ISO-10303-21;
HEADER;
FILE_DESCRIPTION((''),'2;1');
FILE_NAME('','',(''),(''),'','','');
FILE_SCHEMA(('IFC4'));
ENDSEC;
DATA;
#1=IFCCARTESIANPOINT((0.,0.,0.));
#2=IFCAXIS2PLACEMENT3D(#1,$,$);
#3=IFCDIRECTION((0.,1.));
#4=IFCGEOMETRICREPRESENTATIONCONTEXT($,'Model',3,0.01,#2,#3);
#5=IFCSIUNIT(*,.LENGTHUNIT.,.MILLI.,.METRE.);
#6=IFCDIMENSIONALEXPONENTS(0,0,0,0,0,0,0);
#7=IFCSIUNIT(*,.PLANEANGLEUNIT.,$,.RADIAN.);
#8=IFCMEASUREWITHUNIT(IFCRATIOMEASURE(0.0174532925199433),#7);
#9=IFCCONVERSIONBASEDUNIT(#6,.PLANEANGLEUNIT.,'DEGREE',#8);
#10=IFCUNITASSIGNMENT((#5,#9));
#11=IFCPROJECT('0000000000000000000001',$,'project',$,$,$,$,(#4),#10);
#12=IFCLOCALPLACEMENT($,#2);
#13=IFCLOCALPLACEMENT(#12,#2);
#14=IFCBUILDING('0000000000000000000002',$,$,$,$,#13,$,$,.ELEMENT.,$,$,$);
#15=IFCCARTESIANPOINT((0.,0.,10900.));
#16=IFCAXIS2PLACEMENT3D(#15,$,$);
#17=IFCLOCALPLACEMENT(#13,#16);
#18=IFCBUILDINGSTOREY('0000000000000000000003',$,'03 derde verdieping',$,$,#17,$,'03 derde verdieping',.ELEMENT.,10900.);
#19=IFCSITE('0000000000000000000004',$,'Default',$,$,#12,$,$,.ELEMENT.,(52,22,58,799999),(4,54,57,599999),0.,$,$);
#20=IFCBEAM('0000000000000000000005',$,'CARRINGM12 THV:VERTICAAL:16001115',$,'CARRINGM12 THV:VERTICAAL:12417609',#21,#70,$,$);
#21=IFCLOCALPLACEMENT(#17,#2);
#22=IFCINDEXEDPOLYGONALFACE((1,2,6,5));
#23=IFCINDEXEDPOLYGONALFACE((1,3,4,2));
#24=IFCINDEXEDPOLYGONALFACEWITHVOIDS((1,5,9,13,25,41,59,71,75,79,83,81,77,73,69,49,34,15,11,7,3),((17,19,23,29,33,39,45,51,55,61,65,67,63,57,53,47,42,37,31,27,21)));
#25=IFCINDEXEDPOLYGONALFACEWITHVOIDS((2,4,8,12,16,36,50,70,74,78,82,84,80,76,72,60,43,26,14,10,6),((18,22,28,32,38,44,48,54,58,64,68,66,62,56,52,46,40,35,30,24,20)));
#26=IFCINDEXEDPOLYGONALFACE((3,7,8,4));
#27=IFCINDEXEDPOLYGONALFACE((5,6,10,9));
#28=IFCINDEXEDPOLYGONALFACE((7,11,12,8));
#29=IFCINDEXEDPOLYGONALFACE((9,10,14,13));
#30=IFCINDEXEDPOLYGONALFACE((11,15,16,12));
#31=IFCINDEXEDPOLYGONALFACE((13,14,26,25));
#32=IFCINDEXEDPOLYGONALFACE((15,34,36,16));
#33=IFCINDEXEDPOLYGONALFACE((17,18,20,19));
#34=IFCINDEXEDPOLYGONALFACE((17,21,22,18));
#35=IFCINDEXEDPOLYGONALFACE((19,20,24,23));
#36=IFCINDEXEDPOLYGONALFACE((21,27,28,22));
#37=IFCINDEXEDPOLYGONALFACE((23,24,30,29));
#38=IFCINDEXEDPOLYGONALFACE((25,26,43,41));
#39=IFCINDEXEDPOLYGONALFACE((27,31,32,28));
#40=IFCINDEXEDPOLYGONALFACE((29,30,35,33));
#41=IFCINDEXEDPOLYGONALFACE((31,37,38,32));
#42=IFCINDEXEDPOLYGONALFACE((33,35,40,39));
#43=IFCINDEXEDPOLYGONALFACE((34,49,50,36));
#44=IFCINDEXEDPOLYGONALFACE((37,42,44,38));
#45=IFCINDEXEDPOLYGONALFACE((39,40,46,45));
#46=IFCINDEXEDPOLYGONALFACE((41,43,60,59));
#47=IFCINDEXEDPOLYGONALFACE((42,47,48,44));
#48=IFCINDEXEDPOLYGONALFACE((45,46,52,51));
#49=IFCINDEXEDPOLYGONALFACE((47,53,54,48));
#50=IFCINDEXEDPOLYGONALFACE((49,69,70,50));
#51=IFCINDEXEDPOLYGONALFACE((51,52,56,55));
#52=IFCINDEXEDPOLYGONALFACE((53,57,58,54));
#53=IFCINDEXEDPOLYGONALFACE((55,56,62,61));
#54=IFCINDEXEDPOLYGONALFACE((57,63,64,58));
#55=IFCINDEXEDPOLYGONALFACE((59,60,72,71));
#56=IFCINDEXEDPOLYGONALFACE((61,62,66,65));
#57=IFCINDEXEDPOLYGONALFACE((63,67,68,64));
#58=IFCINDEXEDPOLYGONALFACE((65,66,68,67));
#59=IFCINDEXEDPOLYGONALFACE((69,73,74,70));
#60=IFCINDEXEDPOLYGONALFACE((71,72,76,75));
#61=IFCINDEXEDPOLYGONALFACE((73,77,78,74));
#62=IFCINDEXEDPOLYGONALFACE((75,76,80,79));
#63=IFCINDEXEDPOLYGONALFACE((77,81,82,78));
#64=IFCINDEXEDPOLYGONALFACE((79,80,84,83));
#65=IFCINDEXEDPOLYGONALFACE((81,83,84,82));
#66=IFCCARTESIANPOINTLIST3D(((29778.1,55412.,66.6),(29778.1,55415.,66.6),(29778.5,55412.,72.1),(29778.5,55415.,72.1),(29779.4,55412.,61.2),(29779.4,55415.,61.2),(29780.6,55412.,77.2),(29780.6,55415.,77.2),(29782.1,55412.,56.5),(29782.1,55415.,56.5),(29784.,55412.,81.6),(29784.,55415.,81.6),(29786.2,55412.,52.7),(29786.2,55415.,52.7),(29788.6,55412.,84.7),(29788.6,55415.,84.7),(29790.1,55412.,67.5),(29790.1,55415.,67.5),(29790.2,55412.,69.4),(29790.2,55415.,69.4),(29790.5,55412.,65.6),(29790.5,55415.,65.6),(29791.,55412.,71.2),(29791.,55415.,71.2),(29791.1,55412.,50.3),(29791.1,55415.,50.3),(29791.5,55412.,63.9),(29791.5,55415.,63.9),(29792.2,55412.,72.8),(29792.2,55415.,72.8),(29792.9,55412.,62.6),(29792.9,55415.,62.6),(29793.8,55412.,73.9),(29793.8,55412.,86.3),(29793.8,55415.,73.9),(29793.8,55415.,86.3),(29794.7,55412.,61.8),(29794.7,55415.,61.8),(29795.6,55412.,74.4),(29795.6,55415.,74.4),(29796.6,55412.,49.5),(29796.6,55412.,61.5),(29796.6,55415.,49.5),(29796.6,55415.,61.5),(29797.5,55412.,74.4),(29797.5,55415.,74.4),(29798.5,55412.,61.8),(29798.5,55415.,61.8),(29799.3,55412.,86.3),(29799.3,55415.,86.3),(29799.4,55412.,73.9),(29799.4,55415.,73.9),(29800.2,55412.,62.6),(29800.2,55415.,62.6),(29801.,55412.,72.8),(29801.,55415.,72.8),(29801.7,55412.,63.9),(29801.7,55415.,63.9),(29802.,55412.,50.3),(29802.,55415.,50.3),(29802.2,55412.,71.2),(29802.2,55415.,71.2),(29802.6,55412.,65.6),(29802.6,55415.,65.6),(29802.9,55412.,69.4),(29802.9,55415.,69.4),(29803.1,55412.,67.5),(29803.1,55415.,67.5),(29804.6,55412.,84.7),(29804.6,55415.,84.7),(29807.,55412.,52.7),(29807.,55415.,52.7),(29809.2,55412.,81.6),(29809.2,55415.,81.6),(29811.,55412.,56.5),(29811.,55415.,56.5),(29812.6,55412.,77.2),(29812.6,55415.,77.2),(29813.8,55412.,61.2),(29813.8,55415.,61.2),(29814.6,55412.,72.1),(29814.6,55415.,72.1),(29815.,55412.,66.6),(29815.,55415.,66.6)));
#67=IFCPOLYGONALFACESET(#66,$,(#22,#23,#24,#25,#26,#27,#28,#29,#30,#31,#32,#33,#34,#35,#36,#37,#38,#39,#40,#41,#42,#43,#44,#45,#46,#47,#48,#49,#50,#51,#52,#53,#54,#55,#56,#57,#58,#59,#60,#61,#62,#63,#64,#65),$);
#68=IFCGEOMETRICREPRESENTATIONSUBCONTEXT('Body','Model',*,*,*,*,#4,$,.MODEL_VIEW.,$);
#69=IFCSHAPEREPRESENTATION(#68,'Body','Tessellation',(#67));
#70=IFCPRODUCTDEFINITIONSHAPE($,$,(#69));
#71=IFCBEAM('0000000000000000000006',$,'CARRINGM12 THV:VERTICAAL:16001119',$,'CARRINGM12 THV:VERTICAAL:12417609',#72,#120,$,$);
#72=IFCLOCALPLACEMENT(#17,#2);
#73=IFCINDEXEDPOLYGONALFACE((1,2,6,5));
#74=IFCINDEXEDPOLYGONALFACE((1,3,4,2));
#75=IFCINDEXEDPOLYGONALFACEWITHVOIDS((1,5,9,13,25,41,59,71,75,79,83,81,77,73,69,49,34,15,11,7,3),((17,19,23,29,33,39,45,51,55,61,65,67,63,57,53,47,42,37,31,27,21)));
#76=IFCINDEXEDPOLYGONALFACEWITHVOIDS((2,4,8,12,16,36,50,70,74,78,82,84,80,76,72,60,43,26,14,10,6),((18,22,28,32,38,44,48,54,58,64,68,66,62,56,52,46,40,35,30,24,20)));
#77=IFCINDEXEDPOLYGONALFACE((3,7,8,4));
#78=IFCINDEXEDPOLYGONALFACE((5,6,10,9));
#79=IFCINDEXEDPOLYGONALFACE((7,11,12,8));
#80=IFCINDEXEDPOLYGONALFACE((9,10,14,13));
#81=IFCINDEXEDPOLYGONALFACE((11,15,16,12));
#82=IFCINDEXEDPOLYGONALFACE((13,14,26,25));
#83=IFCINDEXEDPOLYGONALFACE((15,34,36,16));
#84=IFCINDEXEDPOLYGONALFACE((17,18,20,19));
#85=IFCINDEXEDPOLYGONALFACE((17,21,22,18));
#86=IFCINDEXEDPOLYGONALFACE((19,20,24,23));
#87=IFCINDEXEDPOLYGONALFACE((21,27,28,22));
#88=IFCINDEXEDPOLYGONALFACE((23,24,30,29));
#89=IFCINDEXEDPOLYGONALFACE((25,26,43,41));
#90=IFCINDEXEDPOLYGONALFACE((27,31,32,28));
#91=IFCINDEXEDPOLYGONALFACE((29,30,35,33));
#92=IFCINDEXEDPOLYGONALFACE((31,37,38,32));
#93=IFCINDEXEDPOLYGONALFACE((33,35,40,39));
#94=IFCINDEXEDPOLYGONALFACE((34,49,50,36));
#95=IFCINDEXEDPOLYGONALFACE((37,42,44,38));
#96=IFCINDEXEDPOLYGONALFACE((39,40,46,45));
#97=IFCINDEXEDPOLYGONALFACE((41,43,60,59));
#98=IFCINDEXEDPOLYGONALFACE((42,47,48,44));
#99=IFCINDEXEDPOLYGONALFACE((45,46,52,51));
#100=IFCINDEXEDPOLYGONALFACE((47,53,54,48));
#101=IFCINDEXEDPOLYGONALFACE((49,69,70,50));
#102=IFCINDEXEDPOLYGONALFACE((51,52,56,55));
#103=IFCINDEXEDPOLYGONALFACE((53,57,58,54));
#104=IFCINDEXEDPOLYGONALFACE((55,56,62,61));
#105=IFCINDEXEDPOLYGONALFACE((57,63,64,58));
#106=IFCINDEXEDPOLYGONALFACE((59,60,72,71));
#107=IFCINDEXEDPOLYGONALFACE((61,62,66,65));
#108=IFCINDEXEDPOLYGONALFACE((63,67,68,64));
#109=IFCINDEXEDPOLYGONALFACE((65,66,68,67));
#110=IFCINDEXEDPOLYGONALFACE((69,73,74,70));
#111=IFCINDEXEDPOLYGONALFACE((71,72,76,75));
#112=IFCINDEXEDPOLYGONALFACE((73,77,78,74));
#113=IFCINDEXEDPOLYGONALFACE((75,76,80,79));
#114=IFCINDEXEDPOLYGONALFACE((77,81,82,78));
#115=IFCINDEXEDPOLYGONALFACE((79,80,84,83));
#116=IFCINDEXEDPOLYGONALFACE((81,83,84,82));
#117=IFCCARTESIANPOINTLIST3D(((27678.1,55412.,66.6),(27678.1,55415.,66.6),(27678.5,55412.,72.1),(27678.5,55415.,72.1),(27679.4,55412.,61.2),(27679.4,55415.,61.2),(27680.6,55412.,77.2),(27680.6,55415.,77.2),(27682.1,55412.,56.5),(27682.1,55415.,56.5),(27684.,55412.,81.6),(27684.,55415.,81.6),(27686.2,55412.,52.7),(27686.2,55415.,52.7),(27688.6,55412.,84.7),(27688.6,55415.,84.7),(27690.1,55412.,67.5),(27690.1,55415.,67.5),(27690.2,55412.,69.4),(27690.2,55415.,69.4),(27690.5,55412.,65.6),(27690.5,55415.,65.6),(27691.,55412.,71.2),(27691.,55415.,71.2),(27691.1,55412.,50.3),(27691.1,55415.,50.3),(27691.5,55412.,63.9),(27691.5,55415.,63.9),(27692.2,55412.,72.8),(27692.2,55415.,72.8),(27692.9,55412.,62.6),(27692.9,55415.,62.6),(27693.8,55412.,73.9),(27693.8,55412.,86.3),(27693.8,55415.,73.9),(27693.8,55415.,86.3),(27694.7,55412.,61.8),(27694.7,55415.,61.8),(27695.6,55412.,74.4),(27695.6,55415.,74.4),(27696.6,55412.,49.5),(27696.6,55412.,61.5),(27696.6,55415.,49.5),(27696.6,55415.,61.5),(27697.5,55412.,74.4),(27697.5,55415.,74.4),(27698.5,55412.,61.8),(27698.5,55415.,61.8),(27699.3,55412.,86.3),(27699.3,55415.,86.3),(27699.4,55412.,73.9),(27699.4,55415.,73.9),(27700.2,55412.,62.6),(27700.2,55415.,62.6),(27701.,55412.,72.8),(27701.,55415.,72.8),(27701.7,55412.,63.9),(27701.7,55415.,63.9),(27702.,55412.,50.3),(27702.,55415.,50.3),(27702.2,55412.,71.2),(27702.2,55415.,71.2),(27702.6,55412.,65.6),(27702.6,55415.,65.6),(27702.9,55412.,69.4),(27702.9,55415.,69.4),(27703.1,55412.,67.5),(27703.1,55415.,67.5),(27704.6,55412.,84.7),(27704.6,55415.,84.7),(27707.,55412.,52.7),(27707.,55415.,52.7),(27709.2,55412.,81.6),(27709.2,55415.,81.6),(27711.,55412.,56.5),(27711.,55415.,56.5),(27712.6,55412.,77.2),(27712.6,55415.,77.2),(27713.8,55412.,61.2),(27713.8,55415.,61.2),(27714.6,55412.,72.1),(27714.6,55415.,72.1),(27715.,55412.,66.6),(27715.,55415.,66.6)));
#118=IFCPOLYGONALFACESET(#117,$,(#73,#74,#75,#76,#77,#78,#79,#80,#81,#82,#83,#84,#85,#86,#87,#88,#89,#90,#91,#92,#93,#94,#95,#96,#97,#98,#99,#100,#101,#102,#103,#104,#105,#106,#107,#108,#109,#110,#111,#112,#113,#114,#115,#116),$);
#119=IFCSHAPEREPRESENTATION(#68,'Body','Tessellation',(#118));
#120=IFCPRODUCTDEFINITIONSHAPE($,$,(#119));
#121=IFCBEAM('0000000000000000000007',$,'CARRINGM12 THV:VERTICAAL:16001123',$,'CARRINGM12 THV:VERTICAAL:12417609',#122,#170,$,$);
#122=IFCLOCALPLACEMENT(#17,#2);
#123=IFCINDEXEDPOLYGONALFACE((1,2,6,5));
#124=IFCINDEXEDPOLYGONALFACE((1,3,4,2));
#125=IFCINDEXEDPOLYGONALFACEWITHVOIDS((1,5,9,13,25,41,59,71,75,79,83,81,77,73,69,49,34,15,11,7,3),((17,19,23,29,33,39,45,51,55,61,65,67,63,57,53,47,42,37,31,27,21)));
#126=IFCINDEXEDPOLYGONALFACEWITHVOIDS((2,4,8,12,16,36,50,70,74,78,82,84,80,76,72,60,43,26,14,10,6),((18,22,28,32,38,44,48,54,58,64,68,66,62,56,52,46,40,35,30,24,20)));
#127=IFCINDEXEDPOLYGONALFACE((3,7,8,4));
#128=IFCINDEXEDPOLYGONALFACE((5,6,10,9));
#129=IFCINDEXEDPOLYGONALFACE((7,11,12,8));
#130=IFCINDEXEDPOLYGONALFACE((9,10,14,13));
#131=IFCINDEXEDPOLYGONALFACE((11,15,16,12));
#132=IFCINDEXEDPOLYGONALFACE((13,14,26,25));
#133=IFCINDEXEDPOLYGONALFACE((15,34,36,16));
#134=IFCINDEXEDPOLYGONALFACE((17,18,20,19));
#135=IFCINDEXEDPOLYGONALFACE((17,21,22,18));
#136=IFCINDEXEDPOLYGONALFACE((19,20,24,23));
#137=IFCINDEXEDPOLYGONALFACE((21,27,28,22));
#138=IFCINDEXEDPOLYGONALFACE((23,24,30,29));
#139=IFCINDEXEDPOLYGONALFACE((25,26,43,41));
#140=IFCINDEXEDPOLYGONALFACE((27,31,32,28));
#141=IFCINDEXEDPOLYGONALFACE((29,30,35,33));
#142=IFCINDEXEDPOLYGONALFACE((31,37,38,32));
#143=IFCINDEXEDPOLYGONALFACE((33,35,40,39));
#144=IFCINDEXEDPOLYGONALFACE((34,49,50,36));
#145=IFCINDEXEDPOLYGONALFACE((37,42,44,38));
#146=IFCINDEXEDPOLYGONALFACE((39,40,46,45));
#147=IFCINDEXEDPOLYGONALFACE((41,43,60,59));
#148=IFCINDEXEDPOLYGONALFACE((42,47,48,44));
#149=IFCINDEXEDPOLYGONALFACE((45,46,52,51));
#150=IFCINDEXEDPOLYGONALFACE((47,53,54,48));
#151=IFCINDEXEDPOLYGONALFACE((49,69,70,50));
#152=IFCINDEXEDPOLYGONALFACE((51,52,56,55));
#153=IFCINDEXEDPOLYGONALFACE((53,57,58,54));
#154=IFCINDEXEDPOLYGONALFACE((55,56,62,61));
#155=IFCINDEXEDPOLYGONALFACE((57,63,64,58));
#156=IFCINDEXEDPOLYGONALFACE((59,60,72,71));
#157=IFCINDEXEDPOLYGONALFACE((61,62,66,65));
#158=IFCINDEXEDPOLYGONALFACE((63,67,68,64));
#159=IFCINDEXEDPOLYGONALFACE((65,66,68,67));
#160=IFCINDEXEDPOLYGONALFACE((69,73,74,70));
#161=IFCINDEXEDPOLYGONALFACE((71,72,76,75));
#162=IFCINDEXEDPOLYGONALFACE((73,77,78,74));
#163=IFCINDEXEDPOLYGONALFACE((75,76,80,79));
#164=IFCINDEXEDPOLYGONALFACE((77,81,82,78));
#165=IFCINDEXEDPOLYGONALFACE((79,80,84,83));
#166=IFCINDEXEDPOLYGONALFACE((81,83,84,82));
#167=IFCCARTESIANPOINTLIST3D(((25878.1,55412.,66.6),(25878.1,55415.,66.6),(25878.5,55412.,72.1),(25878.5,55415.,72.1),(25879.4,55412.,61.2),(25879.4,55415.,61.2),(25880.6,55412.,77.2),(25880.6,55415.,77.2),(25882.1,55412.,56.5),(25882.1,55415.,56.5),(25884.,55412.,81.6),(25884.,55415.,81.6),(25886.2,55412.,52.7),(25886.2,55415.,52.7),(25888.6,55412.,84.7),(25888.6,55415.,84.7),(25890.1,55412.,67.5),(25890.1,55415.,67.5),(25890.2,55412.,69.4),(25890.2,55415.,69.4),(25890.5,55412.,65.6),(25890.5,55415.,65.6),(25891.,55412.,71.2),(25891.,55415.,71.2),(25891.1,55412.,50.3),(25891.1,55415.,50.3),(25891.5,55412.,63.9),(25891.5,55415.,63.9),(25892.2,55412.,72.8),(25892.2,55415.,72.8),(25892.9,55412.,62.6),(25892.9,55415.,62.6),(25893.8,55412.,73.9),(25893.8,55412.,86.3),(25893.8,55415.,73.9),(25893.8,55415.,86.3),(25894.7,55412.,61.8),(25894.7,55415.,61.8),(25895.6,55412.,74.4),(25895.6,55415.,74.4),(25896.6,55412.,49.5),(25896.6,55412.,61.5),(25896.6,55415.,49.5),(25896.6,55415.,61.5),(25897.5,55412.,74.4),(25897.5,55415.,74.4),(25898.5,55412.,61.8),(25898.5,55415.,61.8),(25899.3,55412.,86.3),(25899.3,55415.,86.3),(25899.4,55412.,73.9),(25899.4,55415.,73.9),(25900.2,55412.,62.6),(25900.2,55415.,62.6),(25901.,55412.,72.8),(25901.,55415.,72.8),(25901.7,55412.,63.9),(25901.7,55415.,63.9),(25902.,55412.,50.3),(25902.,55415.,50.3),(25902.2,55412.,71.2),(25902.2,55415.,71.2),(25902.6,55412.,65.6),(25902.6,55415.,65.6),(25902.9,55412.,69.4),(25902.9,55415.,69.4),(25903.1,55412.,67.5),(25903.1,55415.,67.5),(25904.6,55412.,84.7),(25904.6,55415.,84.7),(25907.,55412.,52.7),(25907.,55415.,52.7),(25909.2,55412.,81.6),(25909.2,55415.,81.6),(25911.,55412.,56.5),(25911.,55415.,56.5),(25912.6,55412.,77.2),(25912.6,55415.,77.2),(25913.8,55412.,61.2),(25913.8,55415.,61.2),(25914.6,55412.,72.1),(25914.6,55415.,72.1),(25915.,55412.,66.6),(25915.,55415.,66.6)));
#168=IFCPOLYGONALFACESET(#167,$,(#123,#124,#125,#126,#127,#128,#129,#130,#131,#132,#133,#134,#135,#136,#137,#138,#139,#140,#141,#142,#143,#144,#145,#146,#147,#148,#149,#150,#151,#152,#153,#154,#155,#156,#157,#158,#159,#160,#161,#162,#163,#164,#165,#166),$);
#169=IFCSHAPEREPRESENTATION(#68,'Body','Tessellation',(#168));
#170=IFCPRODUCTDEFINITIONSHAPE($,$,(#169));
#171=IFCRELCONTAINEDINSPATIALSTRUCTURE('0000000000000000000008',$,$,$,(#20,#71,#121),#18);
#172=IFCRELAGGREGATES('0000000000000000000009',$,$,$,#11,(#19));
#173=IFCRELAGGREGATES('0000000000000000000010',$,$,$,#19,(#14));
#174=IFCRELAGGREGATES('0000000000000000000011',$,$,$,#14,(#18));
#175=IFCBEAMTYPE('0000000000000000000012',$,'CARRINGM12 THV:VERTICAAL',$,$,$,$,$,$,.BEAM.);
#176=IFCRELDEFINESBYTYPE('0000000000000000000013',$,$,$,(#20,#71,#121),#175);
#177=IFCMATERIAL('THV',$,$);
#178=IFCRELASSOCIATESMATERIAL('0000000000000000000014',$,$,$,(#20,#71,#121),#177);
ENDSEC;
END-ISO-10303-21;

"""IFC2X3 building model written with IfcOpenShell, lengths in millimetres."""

from ifc_helpers import new_model, entity, si_unit, converted_unit, direction, frame, origin, origin_2d_with_axis, place, context, subcontext, project, spatial, hollow_circle, extrude, material, type_object, element, save


model = new_model("IFC2X3")

# Units and contexts
model_context = context("Model", 3, precision=0.01, world=origin(), true_north=direction((0.0, 1.0)))
body_context = subcontext(model_context, "Body", "Model", "MODEL_VIEW")
ifc_project = project(units=[si_unit("LENGTHUNIT", "METRE", prefix="MILLI"), converted_unit("PLANEANGLEUNIT", "DEGREE", entity("IfcRatioMeasure", 0.0174532925199433), si_unit("PLANEANGLEUNIT", "RADIAN"), dimensions=[0, 0, 0, 0, 0, 0, 0])], contexts=[model_context])

# Site, building, storey
site_placement = place(None, origin())
site = spatial("IfcSite", under=ifc_project, at=site_placement, Name="Default", CompositionType="ELEMENT", RefLatitude=(52, 22, 58, 799999), RefLongitude=(4, 54, 57, 599999), RefElevation=0.0)
building_placement = place(site_placement, origin())
building = spatial("IfcBuilding", under=site, at=building_placement, CompositionType="ELEMENT")
storey_placement = place(building_placement, frame((0.0, 0.0, 10900.0)))
storey = spatial("IfcBuildingStorey", under=building, at=storey_placement, Name="03 derde verdieping", LongName="03 derde verdieping", CompositionType="ELEMENT", Elevation=10900.0)

# Beams
ifc_material_1 = material(Name="THV")
beam_type_1 = type_object("IfcBeamType", Name="CARRINGM12 THV:VERTICAAL", PredefinedType="BEAM")
beam_1_placement = place(storey_placement, origin())
element("IfcBeam", 1, at=beam_1_placement, inside=storey, type_object=beam_type_1, material=ifc_material_1, Name="CARRINGM12 THV:VERTICAAL:16001115", ObjectType="CARRINGM12 THV:VERTICAAL:12417609", context=body_context, shape_type="SweptSolid", body=[
    extrude(hollow_circle(Radius=18.5, WallThickness=12.0, at=origin_2d_with_axis()), frame((29796.6, 55412.0, 68.0), z_axis=(0.0, 1.0, 0.0), x_axis=(0.0, 0.0, -1.0)), (0.0, 0.0, 1.0), 3.0),
])
beam_2_placement = place(storey_placement, origin())
element("IfcBeam", 2, at=beam_2_placement, inside=storey, type_object=beam_type_1, material=ifc_material_1, Name="CARRINGM12 THV:VERTICAAL:16001119", ObjectType="CARRINGM12 THV:VERTICAAL:12417609", context=body_context, shape_type="SweptSolid", body=[
    extrude(hollow_circle(Radius=18.5, WallThickness=12.0, at=origin_2d_with_axis()), frame((27696.6, 55412.0, 68.0), z_axis=(0.0, 1.0, 0.0), x_axis=(0.0, 0.0, -1.0)), (0.0, 0.0, 1.0), 3.0),
])
beam_3_placement = place(storey_placement, origin())
element("IfcBeam", 3, at=beam_3_placement, inside=storey, type_object=beam_type_1, material=ifc_material_1, Name="CARRINGM12 THV:VERTICAAL:16001123", ObjectType="CARRINGM12 THV:VERTICAAL:12417609", context=body_context, shape_type="SweptSolid", body=[
    extrude(hollow_circle(Radius=18.5, WallThickness=12.0, at=origin_2d_with_axis()), frame((25896.6, 55412.0, 68.0), z_axis=(0.0, 1.0, 0.0), x_axis=(0.0, 0.0, -1.0)), (0.0, 0.0, 1.0), 3.0),
])

save(model, "model.ifc")
